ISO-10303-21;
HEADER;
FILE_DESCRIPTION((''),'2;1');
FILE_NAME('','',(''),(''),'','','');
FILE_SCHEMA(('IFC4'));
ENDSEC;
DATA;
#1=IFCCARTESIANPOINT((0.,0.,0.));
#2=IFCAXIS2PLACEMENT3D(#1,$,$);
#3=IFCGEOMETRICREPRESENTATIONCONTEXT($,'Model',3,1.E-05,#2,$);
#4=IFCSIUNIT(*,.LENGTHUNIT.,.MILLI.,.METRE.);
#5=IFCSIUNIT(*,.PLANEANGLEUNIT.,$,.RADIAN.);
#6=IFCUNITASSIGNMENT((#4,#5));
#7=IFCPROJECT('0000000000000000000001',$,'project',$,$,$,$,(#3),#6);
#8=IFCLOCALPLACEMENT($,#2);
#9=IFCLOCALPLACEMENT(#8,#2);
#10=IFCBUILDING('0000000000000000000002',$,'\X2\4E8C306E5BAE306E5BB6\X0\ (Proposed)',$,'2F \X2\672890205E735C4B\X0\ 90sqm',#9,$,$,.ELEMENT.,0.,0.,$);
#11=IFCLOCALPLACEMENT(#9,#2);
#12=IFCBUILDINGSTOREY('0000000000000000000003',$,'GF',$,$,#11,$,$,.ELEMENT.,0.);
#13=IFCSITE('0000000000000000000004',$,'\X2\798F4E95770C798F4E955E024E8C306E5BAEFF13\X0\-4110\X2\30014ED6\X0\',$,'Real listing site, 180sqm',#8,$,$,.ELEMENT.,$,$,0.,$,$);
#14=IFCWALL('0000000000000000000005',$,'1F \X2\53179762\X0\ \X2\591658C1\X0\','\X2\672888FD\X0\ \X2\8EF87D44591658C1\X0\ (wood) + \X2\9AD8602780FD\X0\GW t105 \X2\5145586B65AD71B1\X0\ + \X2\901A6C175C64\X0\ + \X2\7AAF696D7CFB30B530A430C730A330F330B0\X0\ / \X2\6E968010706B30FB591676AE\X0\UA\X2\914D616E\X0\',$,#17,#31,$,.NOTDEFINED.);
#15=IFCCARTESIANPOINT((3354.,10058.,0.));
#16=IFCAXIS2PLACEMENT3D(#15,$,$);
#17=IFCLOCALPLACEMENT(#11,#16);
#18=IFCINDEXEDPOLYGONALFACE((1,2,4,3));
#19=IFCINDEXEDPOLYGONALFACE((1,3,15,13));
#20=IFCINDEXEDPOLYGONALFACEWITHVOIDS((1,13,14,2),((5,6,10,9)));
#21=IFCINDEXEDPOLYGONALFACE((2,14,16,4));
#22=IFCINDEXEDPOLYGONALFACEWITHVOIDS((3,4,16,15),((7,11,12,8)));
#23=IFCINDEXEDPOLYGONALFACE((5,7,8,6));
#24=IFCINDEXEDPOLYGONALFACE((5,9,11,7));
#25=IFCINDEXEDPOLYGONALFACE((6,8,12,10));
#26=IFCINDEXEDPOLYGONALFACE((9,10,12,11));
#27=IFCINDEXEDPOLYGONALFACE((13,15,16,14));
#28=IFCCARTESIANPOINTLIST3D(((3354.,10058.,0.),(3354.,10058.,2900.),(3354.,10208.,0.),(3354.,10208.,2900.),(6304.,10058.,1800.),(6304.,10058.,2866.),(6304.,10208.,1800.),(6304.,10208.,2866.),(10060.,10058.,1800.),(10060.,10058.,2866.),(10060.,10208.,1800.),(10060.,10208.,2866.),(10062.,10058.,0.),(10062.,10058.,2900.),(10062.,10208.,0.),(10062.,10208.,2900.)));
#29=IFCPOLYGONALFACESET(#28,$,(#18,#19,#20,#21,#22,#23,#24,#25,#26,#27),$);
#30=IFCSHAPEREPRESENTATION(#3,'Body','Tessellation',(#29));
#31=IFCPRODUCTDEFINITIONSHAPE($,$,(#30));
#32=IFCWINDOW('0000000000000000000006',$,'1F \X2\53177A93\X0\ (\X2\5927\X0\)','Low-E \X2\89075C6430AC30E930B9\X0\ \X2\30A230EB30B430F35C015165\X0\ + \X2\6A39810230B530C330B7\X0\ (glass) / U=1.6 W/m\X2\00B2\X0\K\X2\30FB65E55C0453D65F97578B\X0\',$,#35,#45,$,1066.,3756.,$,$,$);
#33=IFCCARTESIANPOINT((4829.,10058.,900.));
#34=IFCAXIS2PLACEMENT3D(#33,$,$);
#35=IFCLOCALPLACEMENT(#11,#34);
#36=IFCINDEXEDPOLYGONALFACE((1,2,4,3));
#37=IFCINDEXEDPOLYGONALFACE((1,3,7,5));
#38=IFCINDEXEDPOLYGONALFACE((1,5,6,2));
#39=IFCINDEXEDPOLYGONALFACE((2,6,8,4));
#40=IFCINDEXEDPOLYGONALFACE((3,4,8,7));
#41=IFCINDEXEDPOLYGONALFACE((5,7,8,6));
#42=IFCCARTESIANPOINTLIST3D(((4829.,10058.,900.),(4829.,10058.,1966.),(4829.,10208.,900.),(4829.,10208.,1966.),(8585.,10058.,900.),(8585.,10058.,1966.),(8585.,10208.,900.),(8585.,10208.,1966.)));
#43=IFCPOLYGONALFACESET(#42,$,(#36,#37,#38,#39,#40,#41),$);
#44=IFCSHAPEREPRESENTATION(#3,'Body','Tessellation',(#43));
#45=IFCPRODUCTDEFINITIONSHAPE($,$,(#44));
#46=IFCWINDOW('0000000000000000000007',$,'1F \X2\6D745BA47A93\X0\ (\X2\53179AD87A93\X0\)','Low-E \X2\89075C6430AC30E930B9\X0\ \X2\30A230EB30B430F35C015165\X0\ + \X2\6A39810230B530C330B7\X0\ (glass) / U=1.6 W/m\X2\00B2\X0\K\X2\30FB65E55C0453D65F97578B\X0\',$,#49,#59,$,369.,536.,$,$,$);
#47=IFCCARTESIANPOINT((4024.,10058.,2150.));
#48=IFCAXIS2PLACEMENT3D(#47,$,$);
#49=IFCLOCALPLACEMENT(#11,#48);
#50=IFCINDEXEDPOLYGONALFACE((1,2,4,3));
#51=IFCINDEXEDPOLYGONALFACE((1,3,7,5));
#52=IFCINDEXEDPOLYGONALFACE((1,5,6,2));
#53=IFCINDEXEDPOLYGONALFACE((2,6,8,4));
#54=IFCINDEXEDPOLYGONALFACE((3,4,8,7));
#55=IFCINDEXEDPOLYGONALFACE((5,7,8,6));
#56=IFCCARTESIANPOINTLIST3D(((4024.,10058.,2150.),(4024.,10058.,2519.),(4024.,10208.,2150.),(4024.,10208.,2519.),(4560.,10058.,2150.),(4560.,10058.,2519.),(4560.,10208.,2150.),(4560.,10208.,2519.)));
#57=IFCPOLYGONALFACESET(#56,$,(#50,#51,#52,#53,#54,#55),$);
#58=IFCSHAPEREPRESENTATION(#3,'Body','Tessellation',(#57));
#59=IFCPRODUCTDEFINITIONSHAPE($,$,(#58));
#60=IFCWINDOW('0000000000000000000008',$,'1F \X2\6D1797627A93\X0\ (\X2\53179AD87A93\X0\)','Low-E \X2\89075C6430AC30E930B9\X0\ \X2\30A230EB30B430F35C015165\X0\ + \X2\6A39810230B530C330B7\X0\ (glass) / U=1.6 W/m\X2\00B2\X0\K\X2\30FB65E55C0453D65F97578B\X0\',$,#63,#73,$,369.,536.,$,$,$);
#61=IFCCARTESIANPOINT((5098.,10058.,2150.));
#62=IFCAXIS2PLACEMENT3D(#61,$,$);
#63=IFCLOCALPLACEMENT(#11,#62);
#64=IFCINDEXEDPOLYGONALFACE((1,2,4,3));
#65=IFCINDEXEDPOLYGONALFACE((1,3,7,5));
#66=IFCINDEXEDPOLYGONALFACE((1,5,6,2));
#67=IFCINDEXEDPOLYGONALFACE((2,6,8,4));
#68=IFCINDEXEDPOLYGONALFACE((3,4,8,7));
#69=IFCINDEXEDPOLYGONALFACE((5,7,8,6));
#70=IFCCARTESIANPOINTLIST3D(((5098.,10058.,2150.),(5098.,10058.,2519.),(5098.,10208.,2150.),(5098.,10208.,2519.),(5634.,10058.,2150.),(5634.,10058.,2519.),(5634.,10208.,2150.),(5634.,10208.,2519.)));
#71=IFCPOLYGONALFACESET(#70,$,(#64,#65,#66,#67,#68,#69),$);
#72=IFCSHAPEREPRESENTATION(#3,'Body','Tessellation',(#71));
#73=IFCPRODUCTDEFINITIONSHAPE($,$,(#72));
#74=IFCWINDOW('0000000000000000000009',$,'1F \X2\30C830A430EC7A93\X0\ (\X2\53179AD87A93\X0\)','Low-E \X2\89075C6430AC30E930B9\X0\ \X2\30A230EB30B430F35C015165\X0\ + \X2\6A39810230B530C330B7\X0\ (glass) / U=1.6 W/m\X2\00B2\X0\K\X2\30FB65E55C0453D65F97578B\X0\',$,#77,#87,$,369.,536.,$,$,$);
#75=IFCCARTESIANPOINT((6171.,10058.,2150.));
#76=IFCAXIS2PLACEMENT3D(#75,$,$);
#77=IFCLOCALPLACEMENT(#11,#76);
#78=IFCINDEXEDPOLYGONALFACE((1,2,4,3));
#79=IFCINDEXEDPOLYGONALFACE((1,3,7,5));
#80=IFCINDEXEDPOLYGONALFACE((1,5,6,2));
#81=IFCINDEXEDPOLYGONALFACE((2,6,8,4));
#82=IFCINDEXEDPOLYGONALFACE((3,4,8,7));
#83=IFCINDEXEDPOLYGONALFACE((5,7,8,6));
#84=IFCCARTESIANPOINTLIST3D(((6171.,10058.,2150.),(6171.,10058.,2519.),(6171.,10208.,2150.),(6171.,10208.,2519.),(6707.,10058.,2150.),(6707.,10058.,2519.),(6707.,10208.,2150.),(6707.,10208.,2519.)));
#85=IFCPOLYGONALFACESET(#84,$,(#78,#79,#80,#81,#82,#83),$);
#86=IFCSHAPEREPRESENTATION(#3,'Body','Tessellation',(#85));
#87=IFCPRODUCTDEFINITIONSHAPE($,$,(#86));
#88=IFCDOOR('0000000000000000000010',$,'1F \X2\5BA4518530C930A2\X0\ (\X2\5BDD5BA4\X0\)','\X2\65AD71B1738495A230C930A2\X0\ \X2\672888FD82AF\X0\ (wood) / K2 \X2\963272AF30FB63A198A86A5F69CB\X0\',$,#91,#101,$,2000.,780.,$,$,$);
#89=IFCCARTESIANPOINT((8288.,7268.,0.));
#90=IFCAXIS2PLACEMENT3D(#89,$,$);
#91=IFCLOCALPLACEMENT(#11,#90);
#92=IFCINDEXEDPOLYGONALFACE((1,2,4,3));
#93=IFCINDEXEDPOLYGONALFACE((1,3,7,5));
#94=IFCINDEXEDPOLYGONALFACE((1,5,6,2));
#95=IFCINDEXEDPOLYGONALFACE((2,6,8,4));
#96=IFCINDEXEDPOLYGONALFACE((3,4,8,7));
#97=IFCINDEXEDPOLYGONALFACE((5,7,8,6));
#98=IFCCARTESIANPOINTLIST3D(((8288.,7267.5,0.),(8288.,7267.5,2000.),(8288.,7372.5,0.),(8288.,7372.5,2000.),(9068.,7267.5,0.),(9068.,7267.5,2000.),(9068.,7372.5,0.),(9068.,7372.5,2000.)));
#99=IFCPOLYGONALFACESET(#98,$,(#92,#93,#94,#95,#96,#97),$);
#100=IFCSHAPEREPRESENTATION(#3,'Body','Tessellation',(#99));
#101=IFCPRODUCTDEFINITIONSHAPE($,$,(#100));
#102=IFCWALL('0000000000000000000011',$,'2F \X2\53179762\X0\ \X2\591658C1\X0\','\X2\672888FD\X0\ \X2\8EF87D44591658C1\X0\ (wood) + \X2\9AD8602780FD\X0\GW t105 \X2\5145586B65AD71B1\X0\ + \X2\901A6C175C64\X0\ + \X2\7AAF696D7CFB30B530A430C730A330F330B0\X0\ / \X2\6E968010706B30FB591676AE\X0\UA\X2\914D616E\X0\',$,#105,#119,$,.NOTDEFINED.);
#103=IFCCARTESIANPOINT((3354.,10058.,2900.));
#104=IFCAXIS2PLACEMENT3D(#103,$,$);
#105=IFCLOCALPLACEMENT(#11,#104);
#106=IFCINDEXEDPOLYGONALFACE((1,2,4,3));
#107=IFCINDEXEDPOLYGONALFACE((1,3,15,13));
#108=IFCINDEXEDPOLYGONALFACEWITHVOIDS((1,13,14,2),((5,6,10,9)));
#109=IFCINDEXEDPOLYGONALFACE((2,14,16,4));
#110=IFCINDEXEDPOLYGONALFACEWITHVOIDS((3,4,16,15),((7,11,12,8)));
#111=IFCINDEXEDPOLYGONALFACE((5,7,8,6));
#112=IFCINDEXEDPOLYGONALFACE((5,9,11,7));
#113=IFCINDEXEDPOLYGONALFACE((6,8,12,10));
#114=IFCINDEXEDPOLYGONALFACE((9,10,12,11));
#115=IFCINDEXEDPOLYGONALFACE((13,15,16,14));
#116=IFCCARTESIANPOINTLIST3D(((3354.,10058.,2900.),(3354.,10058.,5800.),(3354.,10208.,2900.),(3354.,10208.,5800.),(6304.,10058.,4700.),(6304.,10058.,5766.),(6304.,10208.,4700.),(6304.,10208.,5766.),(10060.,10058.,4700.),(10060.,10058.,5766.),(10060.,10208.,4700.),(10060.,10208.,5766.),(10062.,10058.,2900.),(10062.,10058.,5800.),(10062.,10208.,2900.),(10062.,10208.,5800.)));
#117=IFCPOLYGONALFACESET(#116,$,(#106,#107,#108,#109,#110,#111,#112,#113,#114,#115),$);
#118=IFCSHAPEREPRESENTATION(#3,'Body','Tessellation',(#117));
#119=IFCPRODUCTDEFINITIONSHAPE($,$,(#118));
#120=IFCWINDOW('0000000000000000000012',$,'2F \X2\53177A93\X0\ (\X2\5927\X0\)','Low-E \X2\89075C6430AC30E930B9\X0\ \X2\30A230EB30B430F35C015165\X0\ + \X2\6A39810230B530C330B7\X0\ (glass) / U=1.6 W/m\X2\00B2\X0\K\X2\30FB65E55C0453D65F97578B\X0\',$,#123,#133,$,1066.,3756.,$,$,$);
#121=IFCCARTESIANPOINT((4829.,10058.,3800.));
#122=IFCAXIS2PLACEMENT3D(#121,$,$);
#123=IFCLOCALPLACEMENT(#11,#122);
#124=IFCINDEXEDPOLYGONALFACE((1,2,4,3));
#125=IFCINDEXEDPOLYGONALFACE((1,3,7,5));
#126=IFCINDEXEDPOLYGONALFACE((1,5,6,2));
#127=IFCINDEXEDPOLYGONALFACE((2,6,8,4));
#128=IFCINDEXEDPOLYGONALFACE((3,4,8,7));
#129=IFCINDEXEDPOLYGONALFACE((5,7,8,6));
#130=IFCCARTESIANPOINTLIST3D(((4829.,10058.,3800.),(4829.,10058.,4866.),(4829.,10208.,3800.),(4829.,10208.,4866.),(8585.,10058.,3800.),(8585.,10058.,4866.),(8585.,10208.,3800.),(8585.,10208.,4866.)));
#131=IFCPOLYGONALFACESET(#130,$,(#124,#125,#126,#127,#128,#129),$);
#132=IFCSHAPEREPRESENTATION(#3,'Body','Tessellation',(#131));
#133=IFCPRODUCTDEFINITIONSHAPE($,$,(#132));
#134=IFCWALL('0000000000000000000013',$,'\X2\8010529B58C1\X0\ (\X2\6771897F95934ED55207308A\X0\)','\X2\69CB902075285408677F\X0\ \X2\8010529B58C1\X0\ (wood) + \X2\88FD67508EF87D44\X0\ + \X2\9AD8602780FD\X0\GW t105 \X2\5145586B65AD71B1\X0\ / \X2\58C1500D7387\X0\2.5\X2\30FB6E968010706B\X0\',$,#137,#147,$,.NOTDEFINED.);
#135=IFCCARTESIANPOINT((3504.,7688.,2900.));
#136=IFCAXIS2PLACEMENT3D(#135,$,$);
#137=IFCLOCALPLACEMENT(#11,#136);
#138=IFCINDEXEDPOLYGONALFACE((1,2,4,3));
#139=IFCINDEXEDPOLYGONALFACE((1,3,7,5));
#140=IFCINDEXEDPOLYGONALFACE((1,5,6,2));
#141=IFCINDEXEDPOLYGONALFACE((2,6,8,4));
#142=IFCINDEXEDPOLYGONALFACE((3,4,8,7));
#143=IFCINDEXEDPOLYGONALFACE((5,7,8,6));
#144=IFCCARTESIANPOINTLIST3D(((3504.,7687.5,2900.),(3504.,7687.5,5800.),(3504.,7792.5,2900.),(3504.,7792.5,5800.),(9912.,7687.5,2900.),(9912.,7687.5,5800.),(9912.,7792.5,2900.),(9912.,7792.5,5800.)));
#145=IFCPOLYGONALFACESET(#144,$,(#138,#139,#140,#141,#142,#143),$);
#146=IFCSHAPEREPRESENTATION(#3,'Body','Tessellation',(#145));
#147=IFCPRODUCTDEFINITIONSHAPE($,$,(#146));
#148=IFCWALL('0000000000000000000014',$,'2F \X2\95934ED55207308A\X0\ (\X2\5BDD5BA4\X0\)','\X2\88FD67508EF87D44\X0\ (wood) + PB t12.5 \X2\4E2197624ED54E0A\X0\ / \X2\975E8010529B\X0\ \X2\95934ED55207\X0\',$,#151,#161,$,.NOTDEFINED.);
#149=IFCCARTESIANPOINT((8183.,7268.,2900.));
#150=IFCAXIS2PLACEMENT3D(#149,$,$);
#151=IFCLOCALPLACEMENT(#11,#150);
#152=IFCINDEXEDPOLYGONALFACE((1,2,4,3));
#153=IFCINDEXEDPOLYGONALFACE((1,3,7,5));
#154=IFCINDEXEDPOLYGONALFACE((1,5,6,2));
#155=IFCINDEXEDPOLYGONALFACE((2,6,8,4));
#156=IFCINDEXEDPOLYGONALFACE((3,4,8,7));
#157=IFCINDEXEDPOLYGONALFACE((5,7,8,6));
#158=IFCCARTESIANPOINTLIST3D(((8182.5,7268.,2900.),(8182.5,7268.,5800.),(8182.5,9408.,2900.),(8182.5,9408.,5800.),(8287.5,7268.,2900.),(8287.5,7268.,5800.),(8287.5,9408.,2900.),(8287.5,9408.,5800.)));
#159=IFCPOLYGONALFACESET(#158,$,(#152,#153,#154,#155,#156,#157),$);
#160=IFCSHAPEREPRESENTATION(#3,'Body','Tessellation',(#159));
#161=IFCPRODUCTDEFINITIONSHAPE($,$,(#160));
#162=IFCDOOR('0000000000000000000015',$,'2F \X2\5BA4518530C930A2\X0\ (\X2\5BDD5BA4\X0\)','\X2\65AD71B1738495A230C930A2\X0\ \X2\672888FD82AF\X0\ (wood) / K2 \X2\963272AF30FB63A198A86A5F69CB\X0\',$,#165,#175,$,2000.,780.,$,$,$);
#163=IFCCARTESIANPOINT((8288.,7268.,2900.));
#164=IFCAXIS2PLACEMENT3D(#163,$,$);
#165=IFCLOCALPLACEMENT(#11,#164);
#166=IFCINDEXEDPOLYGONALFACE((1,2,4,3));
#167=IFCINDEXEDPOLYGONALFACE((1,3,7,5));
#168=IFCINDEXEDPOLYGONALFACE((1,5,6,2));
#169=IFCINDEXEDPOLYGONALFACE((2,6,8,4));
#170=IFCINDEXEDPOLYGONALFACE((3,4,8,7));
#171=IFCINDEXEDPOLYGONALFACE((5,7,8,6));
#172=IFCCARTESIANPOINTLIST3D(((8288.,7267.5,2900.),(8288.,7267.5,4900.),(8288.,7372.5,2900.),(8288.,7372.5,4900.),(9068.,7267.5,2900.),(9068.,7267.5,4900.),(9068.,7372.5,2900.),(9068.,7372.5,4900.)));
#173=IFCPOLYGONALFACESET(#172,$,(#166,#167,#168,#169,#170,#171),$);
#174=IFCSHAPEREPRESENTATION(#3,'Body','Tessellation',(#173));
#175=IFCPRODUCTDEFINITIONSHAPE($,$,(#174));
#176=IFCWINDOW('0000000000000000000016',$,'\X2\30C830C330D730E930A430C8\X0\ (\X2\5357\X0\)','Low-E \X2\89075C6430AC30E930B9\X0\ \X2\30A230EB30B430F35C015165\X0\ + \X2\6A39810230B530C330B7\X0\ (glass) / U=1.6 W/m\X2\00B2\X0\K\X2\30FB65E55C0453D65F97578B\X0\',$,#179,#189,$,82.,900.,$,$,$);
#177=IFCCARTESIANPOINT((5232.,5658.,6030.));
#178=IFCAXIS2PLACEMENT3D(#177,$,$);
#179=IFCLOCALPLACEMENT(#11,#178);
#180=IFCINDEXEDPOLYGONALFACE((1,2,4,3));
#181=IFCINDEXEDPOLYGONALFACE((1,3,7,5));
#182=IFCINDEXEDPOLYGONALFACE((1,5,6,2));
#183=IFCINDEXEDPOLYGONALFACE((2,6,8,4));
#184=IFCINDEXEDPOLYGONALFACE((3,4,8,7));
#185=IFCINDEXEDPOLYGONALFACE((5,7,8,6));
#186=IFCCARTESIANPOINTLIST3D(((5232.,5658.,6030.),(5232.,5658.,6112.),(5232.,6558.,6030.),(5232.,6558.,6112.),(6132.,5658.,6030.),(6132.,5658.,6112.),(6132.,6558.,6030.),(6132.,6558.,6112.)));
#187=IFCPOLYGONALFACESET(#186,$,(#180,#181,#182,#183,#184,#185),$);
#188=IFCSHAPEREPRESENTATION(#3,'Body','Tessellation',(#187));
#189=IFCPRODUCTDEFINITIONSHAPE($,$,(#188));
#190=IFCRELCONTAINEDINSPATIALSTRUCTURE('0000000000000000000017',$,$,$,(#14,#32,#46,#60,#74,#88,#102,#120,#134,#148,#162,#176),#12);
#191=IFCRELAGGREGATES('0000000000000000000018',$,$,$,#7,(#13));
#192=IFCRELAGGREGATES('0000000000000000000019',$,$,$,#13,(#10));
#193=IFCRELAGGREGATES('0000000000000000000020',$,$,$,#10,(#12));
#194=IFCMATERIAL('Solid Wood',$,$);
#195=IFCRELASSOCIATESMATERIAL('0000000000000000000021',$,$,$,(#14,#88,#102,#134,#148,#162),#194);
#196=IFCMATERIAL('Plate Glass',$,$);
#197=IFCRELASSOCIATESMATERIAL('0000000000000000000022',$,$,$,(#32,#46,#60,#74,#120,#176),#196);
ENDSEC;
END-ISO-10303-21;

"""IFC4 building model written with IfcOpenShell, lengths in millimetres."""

from ifc_helpers import new_model, si_unit, frame, frame_2d, origin, place, context, project, spatial, rectangle, extrude, material, element, fill, save


model = new_model("IFC4")

# Units and contexts
model_context = context("Model", 3, precision=1e-05, world=origin())
ifc_project = project(units=[si_unit("LENGTHUNIT", "METRE", prefix="MILLI"), si_unit("PLANEANGLEUNIT", "RADIAN")], contexts=[model_context])

# Site, building, storey
site_placement = place(None, origin())
site = spatial("IfcSite", under=ifc_project, at=site_placement, Name="福井県福井市二の宮３-4110、他", ObjectType="Real listing site, 180sqm", CompositionType="ELEMENT", RefElevation=0.0)
building_placement = place(site_placement, origin())
building = spatial("IfcBuilding", under=site, at=building_placement, Name="二の宮の家 (Proposed)", ObjectType="2F 木造平屋 90sqm", CompositionType="ELEMENT", ElevationOfRefHeight=0.0, ElevationOfTerrain=0.0)
storey_placement = place(building_placement, origin())
storey = spatial("IfcBuildingStorey", under=building, at=storey_placement, Name="GF", CompositionType="ELEMENT", Elevation=0.0)

# Wall, openings, windows
ifc_material_1 = material(Name="Solid Wood")
wall_1_placement = place(storey_placement, frame((3354.0, 10058.0, 0.0)))
wall_1 = element("IfcWall", 1, at=wall_1_placement, inside=storey, material=ifc_material_1, Name="1F 北面 外壁", Description="木製 軸組外壁 (wood) + 高性能GW t105 充填断熱 + 通気層 + 窯業系サイディング / 準耐火・外皮UA配慮", PredefinedType="NOTDEFINED", context=model_context, shape_type="SweptSolid", body=[
    extrude(rectangle(XDim=6708.0, YDim=150.0, at=frame_2d((3354.0, 75.0))), frame((3354.0, 10058.0, 0.0)), (0.0, 0.0, 1.0), 2900.0),
])
opening_1_placement = place(storey_placement, frame((4829.0, 10058.0, 900.0)))
opening_1 = element("IfcOpeningElement", 2, at=opening_1_placement, cuts=wall_1, PredefinedType="NOTDEFINED", context=model_context, shape_type="SweptSolid", body=[
    extrude(rectangle(XDim=3756.0, YDim=150.0, at=frame_2d((1878.0, 75.0))), frame((4829.0, 10058.0, 900.0)), (0.0, 0.0, 1.0), 1066.0),
])
opening_2_placement = place(storey_placement, frame((4024.0, 10058.0, 2150.0)))
opening_2 = element("IfcOpeningElement", 3, at=opening_2_placement, cuts=wall_1, PredefinedType="NOTDEFINED", context=model_context, shape_type="SweptSolid", body=[
    extrude(rectangle(XDim=536.0, YDim=150.0, at=frame_2d((268.0, 75.0))), frame((4024.0, 10058.0, 2150.0)), (0.0, 0.0, 1.0), 369.0),
])
opening_3_placement = place(storey_placement, frame((5098.0, 10058.0, 2150.0)))
opening_3 = element("IfcOpeningElement", 4, at=opening_3_placement, cuts=wall_1, PredefinedType="NOTDEFINED", context=model_context, shape_type="SweptSolid", body=[
    extrude(rectangle(XDim=536.0, YDim=150.0, at=frame_2d((268.0, 75.0))), frame((5098.0, 10058.0, 2150.0)), (0.0, 0.0, 1.0), 369.0),
])
opening_4_placement = place(storey_placement, frame((6171.0, 10058.0, 2150.0)))
opening_4 = element("IfcOpeningElement", 5, at=opening_4_placement, cuts=wall_1, PredefinedType="NOTDEFINED", context=model_context, shape_type="SweptSolid", body=[
    extrude(rectangle(XDim=536.0, YDim=150.0, at=frame_2d((268.0, 75.0))), frame((6171.0, 10058.0, 2150.0)), (0.0, 0.0, 1.0), 369.0),
])
ifc_material_2 = material(Name="Plate Glass")
window_1_placement = place(storey_placement, frame((4829.0, 10058.0, 900.0)))
window_1 = element("IfcWindow", 6, at=window_1_placement, inside=storey, material=ifc_material_2, Name="1F 北窓 (大)", Description="Low-E 複層ガラス アルゴン封入 + 樹脂サッシ (glass) / U=1.6 W/m²K・日射取得型", OverallHeight=1066.0, OverallWidth=3756.0, context=model_context, shape_type="SweptSolid", body=[
    extrude(rectangle(XDim=3756.0, YDim=150.0, at=frame_2d((1878.0, 75.0))), frame((4829.0, 10058.0, 900.0)), (0.0, 0.0, 1.0), 1066.0),
])
fill(opening_1, window_1)
window_2_placement = place(storey_placement, frame((4024.0, 10058.0, 2150.0)))
window_2 = element("IfcWindow", 7, at=window_2_placement, inside=storey, material=ifc_material_2, Name="1F 浴室窓 (北高窓)", Description="Low-E 複層ガラス アルゴン封入 + 樹脂サッシ (glass) / U=1.6 W/m²K・日射取得型", OverallHeight=369.0, OverallWidth=536.0, context=model_context, shape_type="SweptSolid", body=[
    extrude(rectangle(XDim=536.0, YDim=150.0, at=frame_2d((268.0, 75.0))), frame((4024.0, 10058.0, 2150.0)), (0.0, 0.0, 1.0), 369.0),
])
fill(opening_2, window_2)
window_3_placement = place(storey_placement, frame((5098.0, 10058.0, 2150.0)))
window_3 = element("IfcWindow", 8, at=window_3_placement, inside=storey, material=ifc_material_2, Name="1F 洗面窓 (北高窓)", Description="Low-E 複層ガラス アルゴン封入 + 樹脂サッシ (glass) / U=1.6 W/m²K・日射取得型", OverallHeight=369.0, OverallWidth=536.0, context=model_context, shape_type="SweptSolid", body=[
    extrude(rectangle(XDim=536.0, YDim=150.0, at=frame_2d((268.0, 75.0))), frame((5098.0, 10058.0, 2150.0)), (0.0, 0.0, 1.0), 369.0),
])
fill(opening_3, window_3)
window_4_placement = place(storey_placement, frame((6171.0, 10058.0, 2150.0)))
window_4 = element("IfcWindow", 9, at=window_4_placement, inside=storey, material=ifc_material_2, Name="1F トイレ窓 (北高窓)", Description="Low-E 複層ガラス アルゴン封入 + 樹脂サッシ (glass) / U=1.6 W/m²K・日射取得型", OverallHeight=369.0, OverallWidth=536.0, context=model_context, shape_type="SweptSolid", body=[
    extrude(rectangle(XDim=536.0, YDim=150.0, at=frame_2d((268.0, 75.0))), frame((6171.0, 10058.0, 2150.0)), (0.0, 0.0, 1.0), 369.0),
])
fill(opening_4, window_4)

# Door
door_1_placement = place(storey_placement, frame((8288.0, 7268.0, 0.0)))
element("IfcDoor", 10, at=door_1_placement, inside=storey, material=ifc_material_1, Name="1F 室内ドア (寝室)", Description="断熱玄関ドア 木製芯 (wood) / K2 防犯・採風機構", OverallHeight=2000.0, OverallWidth=780.0, context=model_context, shape_type="SweptSolid", body=[
    extrude(rectangle(XDim=780.0, YDim=105.0, at=frame_2d((390.0, 52.0))), frame((8288.0, 7268.0, 0.0)), (0.0, 0.0, 1.0), 2000.0),
])

# Wall, opening, window
wall_2_placement = place(storey_placement, frame((3354.0, 10058.0, 2900.0)))
wall_2 = element("IfcWall", 11, at=wall_2_placement, inside=storey, material=ifc_material_1, Name="2F 北面 外壁", Description="木製 軸組外壁 (wood) + 高性能GW t105 充填断熱 + 通気層 + 窯業系サイディング / 準耐火・外皮UA配慮", PredefinedType="NOTDEFINED", context=model_context, shape_type="SweptSolid", body=[
    extrude(rectangle(XDim=6708.0, YDim=150.0, at=frame_2d((3354.0, 75.0))), frame((3354.0, 10058.0, 2900.0)), (0.0, 0.0, 1.0), 2900.0),
])
opening_5_placement = place(storey_placement, frame((4829.0, 10058.0, 3800.0)))
opening_5 = element("IfcOpeningElement", 12, at=opening_5_placement, cuts=wall_2, PredefinedType="NOTDEFINED", context=model_context, shape_type="SweptSolid", body=[
    extrude(rectangle(XDim=3756.0, YDim=150.0, at=frame_2d((1878.0, 75.0))), frame((4829.0, 10058.0, 3800.0)), (0.0, 0.0, 1.0), 1066.0),
])
window_5_placement = place(storey_placement, frame((4829.0, 10058.0, 3800.0)))
window_5 = element("IfcWindow", 13, at=window_5_placement, inside=storey, material=ifc_material_2, Name="2F 北窓 (大)", Description="Low-E 複層ガラス アルゴン封入 + 樹脂サッシ (glass) / U=1.6 W/m²K・日射取得型", OverallHeight=1066.0, OverallWidth=3756.0, context=model_context, shape_type="SweptSolid", body=[
    extrude(rectangle(XDim=3756.0, YDim=150.0, at=frame_2d((1878.0, 75.0))), frame((4829.0, 10058.0, 3800.0)), (0.0, 0.0, 1.0), 1066.0),
])
fill(opening_5, window_5)

# Walls
wall_3_placement = place(storey_placement, frame((3504.0, 7688.0, 2900.0)))
element("IfcWall", 14, at=wall_3_placement, inside=storey, material=ifc_material_1, Name="耐力壁 (東西間仕切り)", Description="構造用合板 耐力壁 (wood) + 製材軸組 + 高性能GW t105 充填断熱 / 壁倍率2.5・準耐火", PredefinedType="NOTDEFINED", context=model_context, shape_type="SweptSolid", body=[
    extrude(rectangle(XDim=6408.0, YDim=105.0, at=frame_2d((3204.0, 52.0))), frame((3504.0, 7688.0, 2900.0)), (0.0, 0.0, 1.0), 2900.0),
])
wall_4_placement = place(storey_placement, frame((8183.0, 7268.0, 2900.0)))
element("IfcWall", 15, at=wall_4_placement, inside=storey, material=ifc_material_1, Name="2F 間仕切り (寝室)", Description="製材軸組 (wood) + PB t12.5 両面仕上 / 非耐力 間仕切", PredefinedType="NOTDEFINED", context=model_context, shape_type="SweptSolid", body=[
    extrude(rectangle(XDim=105.0, YDim=2140.0, at=frame_2d((52.0, 1070.0))), frame((8183.0, 7268.0, 2900.0)), (0.0, 0.0, 1.0), 2900.0),
])

# Door
door_2_placement = place(storey_placement, frame((8288.0, 7268.0, 2900.0)))
element("IfcDoor", 16, at=door_2_placement, inside=storey, material=ifc_material_1, Name="2F 室内ドア (寝室)", Description="断熱玄関ドア 木製芯 (wood) / K2 防犯・採風機構", OverallHeight=2000.0, OverallWidth=780.0, context=model_context, shape_type="SweptSolid", body=[
    extrude(rectangle(XDim=780.0, YDim=105.0, at=frame_2d((390.0, 52.0))), frame((8288.0, 7268.0, 2900.0)), (0.0, 0.0, 1.0), 2000.0),
])

# Window
window_6_placement = place(storey_placement, frame((5232.0, 5658.0, 6030.0)))
element("IfcWindow", 17, at=window_6_placement, inside=storey, material=ifc_material_2, Name="トップライト (南)", Description="Low-E 複層ガラス アルゴン封入 + 樹脂サッシ (glass) / U=1.6 W/m²K・日射取得型", OverallHeight=82.0, OverallWidth=900.0, context=model_context, shape_type="SweptSolid", body=[
    extrude(rectangle(XDim=900.0, YDim=900.0, at=frame_2d((450.0, 450.0))), frame((5232.0, 5658.0, 6030.0)), (0.0, 0.0, 1.0), 82.0),
])

save(model, "model.ifc")
